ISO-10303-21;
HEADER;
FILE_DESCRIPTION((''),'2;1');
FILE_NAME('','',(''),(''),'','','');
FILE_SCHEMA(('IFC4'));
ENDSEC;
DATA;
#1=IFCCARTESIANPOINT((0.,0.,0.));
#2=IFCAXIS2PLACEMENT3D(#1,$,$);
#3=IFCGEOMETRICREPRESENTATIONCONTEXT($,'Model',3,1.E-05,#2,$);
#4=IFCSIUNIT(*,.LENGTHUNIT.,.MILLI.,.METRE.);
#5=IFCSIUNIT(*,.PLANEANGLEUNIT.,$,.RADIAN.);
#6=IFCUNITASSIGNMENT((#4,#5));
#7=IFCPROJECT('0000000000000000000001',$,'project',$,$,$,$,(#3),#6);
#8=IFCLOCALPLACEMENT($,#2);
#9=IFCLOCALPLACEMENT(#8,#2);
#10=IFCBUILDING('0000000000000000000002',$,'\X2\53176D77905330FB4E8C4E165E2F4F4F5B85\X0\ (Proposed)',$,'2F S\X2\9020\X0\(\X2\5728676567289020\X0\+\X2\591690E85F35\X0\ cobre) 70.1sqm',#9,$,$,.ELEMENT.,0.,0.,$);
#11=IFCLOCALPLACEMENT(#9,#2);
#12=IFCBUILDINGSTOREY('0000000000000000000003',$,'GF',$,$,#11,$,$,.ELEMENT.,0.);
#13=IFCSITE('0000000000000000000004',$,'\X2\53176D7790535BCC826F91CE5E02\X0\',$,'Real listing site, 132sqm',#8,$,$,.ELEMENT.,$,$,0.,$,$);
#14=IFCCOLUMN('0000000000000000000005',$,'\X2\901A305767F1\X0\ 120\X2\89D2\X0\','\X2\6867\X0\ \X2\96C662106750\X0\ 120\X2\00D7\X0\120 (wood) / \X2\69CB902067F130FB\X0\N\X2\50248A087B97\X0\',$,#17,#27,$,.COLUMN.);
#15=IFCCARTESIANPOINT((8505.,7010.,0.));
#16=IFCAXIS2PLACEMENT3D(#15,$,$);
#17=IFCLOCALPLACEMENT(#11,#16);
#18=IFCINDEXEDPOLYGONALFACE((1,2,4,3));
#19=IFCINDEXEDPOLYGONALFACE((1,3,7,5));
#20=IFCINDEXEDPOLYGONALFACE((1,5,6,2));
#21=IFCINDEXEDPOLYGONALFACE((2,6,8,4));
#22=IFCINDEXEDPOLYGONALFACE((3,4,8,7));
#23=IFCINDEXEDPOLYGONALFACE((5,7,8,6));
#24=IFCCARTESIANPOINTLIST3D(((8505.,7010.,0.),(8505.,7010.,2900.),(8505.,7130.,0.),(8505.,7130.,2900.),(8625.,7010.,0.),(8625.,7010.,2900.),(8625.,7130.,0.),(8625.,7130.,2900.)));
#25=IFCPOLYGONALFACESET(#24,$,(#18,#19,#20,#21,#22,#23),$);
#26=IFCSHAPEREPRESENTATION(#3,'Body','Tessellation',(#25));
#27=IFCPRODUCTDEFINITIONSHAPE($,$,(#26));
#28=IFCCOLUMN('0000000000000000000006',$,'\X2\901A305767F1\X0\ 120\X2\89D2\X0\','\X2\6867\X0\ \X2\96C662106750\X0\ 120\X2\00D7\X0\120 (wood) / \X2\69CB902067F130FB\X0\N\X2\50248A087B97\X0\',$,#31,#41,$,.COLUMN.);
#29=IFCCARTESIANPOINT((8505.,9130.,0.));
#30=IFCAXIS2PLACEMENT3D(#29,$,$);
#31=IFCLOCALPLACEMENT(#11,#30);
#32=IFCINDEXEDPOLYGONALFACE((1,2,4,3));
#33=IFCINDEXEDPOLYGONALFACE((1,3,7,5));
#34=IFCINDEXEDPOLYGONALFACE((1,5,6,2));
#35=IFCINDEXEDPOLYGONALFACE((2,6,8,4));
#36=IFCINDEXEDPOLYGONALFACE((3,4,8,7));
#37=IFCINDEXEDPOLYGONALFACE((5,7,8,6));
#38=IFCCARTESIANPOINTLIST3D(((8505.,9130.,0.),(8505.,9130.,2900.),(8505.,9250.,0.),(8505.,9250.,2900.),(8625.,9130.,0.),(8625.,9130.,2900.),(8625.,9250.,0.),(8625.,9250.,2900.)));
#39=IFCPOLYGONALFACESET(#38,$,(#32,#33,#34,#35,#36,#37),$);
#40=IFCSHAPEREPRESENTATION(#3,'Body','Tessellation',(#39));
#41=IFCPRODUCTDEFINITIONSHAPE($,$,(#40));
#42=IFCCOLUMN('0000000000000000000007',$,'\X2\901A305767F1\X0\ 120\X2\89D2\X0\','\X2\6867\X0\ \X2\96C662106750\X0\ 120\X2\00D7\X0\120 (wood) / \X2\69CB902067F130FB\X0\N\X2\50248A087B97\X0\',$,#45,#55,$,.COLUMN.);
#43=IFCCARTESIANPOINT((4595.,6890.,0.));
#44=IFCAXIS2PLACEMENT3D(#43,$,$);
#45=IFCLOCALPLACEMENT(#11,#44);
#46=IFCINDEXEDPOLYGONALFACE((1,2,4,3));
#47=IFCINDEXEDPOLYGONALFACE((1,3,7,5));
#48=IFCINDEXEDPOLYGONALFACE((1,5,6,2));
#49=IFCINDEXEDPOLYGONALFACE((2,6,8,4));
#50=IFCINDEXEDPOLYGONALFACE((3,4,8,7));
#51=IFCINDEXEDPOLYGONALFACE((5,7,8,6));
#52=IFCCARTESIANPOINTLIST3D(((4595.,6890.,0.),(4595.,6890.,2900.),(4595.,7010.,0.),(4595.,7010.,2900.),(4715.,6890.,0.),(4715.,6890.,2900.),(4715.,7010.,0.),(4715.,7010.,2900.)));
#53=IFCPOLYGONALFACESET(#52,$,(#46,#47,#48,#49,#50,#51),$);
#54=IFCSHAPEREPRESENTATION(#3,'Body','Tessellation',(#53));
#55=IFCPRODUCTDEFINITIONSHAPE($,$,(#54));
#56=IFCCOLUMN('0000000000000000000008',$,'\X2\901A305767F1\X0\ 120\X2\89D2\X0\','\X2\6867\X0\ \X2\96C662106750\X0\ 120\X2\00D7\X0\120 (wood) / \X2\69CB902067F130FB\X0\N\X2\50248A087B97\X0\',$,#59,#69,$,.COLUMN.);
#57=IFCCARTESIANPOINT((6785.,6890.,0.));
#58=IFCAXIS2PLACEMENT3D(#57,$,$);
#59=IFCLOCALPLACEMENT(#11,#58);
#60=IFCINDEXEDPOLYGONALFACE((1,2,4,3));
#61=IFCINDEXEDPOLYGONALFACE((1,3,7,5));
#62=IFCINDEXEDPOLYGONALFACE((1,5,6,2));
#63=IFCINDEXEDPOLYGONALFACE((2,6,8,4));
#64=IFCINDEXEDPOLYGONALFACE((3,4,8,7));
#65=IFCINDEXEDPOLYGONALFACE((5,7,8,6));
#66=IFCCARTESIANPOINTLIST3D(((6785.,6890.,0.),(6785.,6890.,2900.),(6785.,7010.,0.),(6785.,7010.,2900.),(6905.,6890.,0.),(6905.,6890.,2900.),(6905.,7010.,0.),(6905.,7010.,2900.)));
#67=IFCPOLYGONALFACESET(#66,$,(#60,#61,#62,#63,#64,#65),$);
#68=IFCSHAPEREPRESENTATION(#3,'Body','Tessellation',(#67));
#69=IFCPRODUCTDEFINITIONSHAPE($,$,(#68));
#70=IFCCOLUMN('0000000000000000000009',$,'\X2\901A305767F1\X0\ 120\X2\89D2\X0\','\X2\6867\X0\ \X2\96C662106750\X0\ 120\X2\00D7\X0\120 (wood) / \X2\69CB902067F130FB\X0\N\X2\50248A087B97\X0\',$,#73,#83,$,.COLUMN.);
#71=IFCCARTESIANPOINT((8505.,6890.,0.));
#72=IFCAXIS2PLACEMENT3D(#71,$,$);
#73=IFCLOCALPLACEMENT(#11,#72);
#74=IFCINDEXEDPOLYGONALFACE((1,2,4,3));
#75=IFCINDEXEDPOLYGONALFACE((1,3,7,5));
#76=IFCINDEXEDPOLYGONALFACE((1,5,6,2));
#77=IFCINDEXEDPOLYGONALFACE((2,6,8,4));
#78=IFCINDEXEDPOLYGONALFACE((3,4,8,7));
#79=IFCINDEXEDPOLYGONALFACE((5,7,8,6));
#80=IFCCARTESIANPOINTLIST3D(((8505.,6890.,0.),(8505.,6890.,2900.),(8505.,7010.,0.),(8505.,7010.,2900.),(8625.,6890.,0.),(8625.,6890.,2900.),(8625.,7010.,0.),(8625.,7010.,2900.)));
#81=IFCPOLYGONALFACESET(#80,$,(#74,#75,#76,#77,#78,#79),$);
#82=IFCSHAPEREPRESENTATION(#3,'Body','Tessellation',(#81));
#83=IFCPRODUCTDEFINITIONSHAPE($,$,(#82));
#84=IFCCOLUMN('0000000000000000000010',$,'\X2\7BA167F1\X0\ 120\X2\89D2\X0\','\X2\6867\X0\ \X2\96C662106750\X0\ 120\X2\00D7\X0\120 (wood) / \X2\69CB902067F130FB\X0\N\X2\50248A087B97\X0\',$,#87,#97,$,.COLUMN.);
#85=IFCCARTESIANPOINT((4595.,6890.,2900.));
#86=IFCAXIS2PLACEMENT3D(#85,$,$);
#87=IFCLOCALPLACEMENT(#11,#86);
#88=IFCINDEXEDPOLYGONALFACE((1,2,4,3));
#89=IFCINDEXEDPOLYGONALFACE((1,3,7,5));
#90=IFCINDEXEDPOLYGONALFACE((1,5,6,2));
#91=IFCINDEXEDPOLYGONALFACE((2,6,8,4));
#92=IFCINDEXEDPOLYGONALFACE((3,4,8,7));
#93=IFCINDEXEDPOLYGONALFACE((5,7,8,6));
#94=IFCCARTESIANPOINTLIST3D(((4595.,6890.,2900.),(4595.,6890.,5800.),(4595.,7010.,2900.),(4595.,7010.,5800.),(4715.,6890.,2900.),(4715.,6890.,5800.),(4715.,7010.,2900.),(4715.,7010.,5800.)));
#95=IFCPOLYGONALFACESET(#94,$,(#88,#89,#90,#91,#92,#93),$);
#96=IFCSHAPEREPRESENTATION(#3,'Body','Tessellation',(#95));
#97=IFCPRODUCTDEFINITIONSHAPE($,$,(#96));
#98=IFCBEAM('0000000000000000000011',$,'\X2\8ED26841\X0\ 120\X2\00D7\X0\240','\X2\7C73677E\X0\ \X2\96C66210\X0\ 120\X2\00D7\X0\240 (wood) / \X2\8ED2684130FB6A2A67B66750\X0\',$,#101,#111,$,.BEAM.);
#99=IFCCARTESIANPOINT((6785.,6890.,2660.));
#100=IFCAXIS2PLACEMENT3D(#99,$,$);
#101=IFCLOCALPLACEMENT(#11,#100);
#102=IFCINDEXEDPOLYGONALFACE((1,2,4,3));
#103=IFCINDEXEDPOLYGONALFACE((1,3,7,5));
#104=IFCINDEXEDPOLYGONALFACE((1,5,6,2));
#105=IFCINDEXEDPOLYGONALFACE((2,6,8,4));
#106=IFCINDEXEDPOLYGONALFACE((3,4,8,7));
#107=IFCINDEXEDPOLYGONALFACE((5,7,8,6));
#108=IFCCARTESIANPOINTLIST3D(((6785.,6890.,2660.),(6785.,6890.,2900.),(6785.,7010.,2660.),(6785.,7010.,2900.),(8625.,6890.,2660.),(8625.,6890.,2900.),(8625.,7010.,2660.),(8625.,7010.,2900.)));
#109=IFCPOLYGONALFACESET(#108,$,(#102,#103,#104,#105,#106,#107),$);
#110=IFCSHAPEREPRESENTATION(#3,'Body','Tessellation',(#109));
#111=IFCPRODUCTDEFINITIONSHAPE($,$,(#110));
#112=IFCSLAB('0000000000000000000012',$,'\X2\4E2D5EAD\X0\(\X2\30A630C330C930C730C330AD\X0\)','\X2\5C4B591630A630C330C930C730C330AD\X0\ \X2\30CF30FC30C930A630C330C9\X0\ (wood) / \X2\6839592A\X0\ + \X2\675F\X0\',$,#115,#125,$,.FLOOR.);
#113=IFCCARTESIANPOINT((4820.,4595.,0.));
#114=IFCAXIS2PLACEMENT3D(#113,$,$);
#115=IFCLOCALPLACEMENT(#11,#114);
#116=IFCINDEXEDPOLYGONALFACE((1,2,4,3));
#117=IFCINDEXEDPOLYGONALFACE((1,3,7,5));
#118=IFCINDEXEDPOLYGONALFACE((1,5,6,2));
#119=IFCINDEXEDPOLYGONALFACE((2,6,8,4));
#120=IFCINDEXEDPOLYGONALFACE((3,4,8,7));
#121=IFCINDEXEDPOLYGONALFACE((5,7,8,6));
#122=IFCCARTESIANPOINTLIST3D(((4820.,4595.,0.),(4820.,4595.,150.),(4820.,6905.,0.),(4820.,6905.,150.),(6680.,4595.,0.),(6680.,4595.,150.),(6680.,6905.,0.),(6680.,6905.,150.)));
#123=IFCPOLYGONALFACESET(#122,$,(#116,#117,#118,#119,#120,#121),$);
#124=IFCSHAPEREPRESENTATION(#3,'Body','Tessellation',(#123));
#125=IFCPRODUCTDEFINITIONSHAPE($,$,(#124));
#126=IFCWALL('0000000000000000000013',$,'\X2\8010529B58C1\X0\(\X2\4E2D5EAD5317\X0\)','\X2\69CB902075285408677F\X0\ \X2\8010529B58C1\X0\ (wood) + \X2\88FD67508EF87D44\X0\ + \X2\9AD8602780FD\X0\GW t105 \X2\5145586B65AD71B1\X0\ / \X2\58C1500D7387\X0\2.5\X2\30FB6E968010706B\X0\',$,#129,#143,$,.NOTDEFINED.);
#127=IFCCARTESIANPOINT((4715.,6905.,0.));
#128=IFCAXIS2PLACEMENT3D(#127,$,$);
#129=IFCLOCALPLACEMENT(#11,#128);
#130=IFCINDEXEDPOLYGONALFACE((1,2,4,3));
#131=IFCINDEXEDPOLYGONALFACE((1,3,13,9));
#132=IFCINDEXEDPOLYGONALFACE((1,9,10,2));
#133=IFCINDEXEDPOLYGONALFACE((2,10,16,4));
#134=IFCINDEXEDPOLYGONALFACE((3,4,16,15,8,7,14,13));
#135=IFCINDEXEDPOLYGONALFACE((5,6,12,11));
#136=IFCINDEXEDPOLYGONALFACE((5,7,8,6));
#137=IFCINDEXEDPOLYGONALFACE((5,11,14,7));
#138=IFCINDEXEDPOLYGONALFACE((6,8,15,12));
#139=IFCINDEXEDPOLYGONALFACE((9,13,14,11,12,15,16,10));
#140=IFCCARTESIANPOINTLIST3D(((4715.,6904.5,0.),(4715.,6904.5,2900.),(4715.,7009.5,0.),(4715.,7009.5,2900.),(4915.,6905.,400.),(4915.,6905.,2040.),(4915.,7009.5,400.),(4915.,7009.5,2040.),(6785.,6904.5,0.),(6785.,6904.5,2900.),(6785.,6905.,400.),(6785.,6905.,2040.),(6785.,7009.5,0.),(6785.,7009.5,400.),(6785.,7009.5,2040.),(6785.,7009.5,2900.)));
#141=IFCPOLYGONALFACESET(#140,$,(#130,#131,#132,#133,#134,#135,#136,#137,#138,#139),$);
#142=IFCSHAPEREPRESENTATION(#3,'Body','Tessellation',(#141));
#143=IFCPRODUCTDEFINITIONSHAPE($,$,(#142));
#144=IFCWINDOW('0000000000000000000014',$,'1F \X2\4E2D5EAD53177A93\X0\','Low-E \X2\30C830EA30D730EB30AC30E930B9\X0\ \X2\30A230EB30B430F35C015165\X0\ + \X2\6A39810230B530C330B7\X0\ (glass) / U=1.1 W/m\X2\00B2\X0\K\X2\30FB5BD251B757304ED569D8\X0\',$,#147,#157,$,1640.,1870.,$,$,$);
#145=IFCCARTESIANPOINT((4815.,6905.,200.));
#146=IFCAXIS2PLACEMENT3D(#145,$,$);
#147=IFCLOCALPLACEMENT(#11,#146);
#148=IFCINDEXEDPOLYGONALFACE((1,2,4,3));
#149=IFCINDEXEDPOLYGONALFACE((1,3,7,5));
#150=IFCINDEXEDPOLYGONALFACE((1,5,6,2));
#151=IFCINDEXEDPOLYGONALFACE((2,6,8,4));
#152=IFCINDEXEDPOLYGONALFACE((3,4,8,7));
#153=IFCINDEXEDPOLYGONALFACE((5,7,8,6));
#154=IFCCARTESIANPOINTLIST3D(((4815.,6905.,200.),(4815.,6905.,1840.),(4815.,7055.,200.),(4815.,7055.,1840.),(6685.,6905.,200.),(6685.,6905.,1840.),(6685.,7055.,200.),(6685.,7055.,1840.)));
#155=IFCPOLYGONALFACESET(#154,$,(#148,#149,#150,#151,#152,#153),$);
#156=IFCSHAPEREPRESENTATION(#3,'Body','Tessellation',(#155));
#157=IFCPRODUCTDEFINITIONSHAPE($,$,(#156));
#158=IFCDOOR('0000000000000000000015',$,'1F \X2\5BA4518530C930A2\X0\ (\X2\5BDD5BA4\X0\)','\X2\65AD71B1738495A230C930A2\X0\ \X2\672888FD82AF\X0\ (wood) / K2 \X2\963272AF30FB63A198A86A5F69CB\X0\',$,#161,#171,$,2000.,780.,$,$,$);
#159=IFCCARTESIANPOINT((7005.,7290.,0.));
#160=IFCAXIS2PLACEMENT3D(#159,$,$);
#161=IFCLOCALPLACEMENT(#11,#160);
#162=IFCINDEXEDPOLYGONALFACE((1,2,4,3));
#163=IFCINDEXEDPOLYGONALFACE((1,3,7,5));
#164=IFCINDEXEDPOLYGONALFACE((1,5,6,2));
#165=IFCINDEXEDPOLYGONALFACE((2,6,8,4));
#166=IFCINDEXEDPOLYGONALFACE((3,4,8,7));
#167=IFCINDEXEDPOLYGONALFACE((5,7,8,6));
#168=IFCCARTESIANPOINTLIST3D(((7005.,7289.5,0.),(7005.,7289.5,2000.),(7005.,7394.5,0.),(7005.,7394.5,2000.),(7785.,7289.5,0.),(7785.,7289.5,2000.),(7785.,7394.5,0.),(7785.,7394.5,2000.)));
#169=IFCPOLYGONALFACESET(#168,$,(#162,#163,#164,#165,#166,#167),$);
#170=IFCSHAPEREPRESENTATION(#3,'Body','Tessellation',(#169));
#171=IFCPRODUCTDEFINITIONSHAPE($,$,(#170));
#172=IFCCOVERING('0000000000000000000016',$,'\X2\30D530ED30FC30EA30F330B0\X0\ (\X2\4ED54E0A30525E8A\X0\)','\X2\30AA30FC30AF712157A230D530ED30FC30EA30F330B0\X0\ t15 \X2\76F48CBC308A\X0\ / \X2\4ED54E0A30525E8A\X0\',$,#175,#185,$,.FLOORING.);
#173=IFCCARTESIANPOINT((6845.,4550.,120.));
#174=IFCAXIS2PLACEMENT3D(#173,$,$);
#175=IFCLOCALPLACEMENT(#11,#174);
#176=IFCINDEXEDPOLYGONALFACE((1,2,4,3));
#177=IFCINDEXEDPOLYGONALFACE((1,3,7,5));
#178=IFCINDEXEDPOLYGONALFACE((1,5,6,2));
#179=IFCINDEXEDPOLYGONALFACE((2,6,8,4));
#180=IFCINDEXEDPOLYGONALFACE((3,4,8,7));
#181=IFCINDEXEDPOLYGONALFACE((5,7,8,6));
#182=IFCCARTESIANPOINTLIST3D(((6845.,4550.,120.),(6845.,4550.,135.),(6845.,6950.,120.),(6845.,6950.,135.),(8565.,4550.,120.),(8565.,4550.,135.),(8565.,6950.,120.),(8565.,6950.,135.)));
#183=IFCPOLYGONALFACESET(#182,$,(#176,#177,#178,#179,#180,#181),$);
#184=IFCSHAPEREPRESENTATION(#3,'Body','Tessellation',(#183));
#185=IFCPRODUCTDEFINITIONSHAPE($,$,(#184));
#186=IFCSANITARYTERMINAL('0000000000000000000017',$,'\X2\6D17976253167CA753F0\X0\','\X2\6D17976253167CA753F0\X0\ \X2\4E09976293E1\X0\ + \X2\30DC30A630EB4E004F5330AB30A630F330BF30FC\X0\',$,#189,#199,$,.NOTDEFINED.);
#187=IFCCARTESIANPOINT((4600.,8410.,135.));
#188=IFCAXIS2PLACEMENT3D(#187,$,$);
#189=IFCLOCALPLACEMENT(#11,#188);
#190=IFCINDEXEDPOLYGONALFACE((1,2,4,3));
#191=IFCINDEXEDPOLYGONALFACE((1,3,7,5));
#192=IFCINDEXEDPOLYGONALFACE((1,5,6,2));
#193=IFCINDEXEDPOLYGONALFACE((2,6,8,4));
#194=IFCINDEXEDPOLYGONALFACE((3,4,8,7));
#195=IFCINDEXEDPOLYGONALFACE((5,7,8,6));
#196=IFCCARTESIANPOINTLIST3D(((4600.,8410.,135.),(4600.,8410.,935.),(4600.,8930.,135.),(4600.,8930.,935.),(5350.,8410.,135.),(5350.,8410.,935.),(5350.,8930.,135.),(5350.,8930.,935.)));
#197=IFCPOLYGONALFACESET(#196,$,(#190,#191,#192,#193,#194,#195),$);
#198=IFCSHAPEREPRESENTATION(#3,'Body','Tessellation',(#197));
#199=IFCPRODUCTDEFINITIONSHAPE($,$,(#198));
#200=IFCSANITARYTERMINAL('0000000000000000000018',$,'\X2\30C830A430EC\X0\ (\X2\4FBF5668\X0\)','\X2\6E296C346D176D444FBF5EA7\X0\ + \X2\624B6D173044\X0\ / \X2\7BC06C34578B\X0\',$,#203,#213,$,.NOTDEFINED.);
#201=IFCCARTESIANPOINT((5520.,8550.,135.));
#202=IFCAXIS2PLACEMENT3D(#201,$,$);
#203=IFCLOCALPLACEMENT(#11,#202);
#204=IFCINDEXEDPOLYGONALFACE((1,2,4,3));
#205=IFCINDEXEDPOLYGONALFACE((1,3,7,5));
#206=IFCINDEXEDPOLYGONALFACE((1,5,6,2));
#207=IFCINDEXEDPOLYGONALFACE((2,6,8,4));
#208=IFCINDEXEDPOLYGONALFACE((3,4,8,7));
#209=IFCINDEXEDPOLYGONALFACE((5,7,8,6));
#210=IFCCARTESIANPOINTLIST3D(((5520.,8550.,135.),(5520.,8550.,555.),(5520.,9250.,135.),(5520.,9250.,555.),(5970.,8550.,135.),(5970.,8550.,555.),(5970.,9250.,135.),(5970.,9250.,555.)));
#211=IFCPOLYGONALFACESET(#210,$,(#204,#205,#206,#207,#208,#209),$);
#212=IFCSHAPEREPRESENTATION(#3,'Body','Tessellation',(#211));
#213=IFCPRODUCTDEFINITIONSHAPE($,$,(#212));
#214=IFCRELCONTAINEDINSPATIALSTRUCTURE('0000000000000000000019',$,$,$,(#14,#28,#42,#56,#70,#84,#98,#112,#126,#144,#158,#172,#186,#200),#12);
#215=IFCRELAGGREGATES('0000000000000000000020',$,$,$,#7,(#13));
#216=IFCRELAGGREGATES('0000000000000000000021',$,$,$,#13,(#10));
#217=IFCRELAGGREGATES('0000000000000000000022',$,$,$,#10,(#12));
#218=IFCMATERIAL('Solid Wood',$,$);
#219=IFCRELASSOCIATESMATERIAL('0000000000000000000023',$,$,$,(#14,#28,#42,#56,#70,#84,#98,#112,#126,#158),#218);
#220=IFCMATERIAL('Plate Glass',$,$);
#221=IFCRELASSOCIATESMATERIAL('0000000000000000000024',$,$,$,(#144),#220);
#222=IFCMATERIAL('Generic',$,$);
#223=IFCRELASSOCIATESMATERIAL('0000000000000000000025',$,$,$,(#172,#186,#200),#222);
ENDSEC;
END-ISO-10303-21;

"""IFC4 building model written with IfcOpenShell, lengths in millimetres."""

from ifc_helpers import new_model, si_unit, frame, frame_2d, origin, place, context, project, spatial, rectangle, extrude, material, element, fill, save


model = new_model("IFC4")

# Units and contexts
model_context = context("Model", 3, precision=1e-05, world=origin())
ifc_project = project(units=[si_unit("LENGTHUNIT", "METRE", prefix="MILLI"), si_unit("PLANEANGLEUNIT", "RADIAN")], contexts=[model_context])

# Site, building, storey
site_placement = place(None, origin())
site = spatial("IfcSite", under=ifc_project, at=site_placement, Name="北海道富良野市", ObjectType="Real listing site, 132sqm", CompositionType="ELEMENT", RefElevation=0.0)
building_placement = place(site_placement, origin())
building = spatial("IfcBuilding", under=site, at=building_placement, Name="北海道・二世帯住宅 (Proposed)", ObjectType="2F S造(在来木造+外部張 cobre) 70.1sqm", CompositionType="ELEMENT", ElevationOfRefHeight=0.0, ElevationOfTerrain=0.0)
storey_placement = place(building_placement, origin())
storey = spatial("IfcBuildingStorey", under=building, at=storey_placement, Name="GF", CompositionType="ELEMENT", Elevation=0.0)

# Columns
ifc_material_1 = material(Name="Solid Wood")
column_1_placement = place(storey_placement, frame((8505.0, 7010.0, 0.0)))
element("IfcColumn", 1, at=column_1_placement, inside=storey, material=ifc_material_1, Name="通し柱 120角", Description="桧 集成材 120×120 (wood) / 構造柱・N値計算", PredefinedType="COLUMN", context=model_context, shape_type="SweptSolid", body=[
    extrude(rectangle(XDim=120.0, YDim=120.0, at=frame_2d((60.0, 60.0))), frame((8505.0, 7010.0, 0.0)), (0.0, 0.0, 1.0), 2900.0),
])
column_2_placement = place(storey_placement, frame((8505.0, 9130.0, 0.0)))
element("IfcColumn", 2, at=column_2_placement, inside=storey, material=ifc_material_1, Name="通し柱 120角", Description="桧 集成材 120×120 (wood) / 構造柱・N値計算", PredefinedType="COLUMN", context=model_context, shape_type="SweptSolid", body=[
    extrude(rectangle(XDim=120.0, YDim=120.0, at=frame_2d((60.0, 60.0))), frame((8505.0, 9130.0, 0.0)), (0.0, 0.0, 1.0), 2900.0),
])
column_3_placement = place(storey_placement, frame((4595.0, 6890.0, 0.0)))
element("IfcColumn", 3, at=column_3_placement, inside=storey, material=ifc_material_1, Name="通し柱 120角", Description="桧 集成材 120×120 (wood) / 構造柱・N値計算", PredefinedType="COLUMN", context=model_context, shape_type="SweptSolid", body=[
    extrude(rectangle(XDim=120.0, YDim=120.0, at=frame_2d((60.0, 60.0))), frame((4595.0, 6890.0, 0.0)), (0.0, 0.0, 1.0), 2900.0),
])
column_4_placement = place(storey_placement, frame((6785.0, 6890.0, 0.0)))
element("IfcColumn", 4, at=column_4_placement, inside=storey, material=ifc_material_1, Name="通し柱 120角", Description="桧 集成材 120×120 (wood) / 構造柱・N値計算", PredefinedType="COLUMN", context=model_context, shape_type="SweptSolid", body=[
    extrude(rectangle(XDim=120.0, YDim=120.0, at=frame_2d((60.0, 60.0))), frame((6785.0, 6890.0, 0.0)), (0.0, 0.0, 1.0), 2900.0),
])
column_5_placement = place(storey_placement, frame((8505.0, 6890.0, 0.0)))
element("IfcColumn", 5, at=column_5_placement, inside=storey, material=ifc_material_1, Name="通し柱 120角", Description="桧 集成材 120×120 (wood) / 構造柱・N値計算", PredefinedType="COLUMN", context=model_context, shape_type="SweptSolid", body=[
    extrude(rectangle(XDim=120.0, YDim=120.0, at=frame_2d((60.0, 60.0))), frame((8505.0, 6890.0, 0.0)), (0.0, 0.0, 1.0), 2900.0),
])
column_6_placement = place(storey_placement, frame((4595.0, 6890.0, 2900.0)))
element("IfcColumn", 6, at=column_6_placement, inside=storey, material=ifc_material_1, Name="管柱 120角", Description="桧 集成材 120×120 (wood) / 構造柱・N値計算", PredefinedType="COLUMN", context=model_context, shape_type="SweptSolid", body=[
    extrude(rectangle(XDim=120.0, YDim=120.0, at=frame_2d((60.0, 60.0))), frame((4595.0, 6890.0, 2900.0)), (0.0, 0.0, 1.0), 2900.0),
])

# Beam
beam_1_placement = place(storey_placement, frame((6785.0, 6890.0, 2660.0)))
element("IfcBeam", 7, at=beam_1_placement, inside=storey, material=ifc_material_1, Name="軒桁 120×240", Description="米松 集成 120×240 (wood) / 軒桁・横架材", PredefinedType="BEAM", context=model_context, shape_type="SweptSolid", body=[
    extrude(rectangle(XDim=1840.0, YDim=120.0, at=frame_2d((920.0, 60.0))), frame((6785.0, 6890.0, 2660.0)), (0.0, 0.0, 1.0), 240.0),
])

# Slab
slab_placement = place(storey_placement, frame((4820.0, 4595.0, 0.0)))
element("IfcSlab", 8, at=slab_placement, inside=storey, material=ifc_material_1, Name="中庭(ウッドデッキ)", Description="屋外ウッドデッキ ハードウッド (wood) / 根太 + 束", PredefinedType="FLOOR", context=model_context, shape_type="SweptSolid", body=[
    extrude(rectangle(XDim=1860.0, YDim=2310.0, at=frame_2d((930.0, 1155.0))), frame((4820.0, 4595.0, 0.0)), (0.0, 0.0, 1.0), 150.0),
])

# Wall, opening, window
wall_1_placement = place(storey_placement, frame((4715.0, 6905.0, 0.0)))
wall_1 = element("IfcWall", 9, at=wall_1_placement, inside=storey, material=ifc_material_1, Name="耐力壁(中庭北)", Description="構造用合板 耐力壁 (wood) + 製材軸組 + 高性能GW t105 充填断熱 / 壁倍率2.5・準耐火", PredefinedType="NOTDEFINED", context=model_context, shape_type="SweptSolid", body=[
    extrude(rectangle(XDim=2070.0, YDim=105.0, at=frame_2d((1035.0, 52.0))), frame((4715.0, 6905.0, 0.0)), (0.0, 0.0, 1.0), 2900.0),
])
opening_placement = place(storey_placement, frame((4815.0, 6905.0, 200.0)))
opening = element("IfcOpeningElement", 10, at=opening_placement, cuts=wall_1, PredefinedType="NOTDEFINED", context=model_context, shape_type="SweptSolid", body=[
    extrude(rectangle(XDim=1870.0, YDim=150.0, at=frame_2d((935.0, 75.0))), frame((4815.0, 6905.0, 200.0)), (0.0, 0.0, 1.0), 1640.0),
])
ifc_material_2 = material(Name="Plate Glass")
window_placement = place(storey_placement, frame((4815.0, 6905.0, 200.0)))
window = element("IfcWindow", 11, at=window_placement, inside=storey, material=ifc_material_2, Name="1F 中庭北窓", Description="Low-E トリプルガラス アルゴン封入 + 樹脂サッシ (glass) / U=1.1 W/m²K・寒冷地仕様", OverallHeight=1640.0, OverallWidth=1870.0, context=model_context, shape_type="SweptSolid", body=[
    extrude(rectangle(XDim=1870.0, YDim=150.0, at=frame_2d((935.0, 75.0))), frame((4815.0, 6905.0, 200.0)), (0.0, 0.0, 1.0), 1640.0),
])
fill(opening, window)

# Door
door_placement = place(storey_placement, frame((7005.0, 7290.0, 0.0)))
element("IfcDoor", 12, at=door_placement, inside=storey, material=ifc_material_1, Name="1F 室内ドア (寝室)", Description="断熱玄関ドア 木製芯 (wood) / K2 防犯・採風機構", OverallHeight=2000.0, OverallWidth=780.0, context=model_context, shape_type="SweptSolid", body=[
    extrude(rectangle(XDim=780.0, YDim=105.0, at=frame_2d((390.0, 52.0))), frame((7005.0, 7290.0, 0.0)), (0.0, 0.0, 1.0), 2000.0),
])

# Covering
ifc_material_3 = material(Name="Generic")
covering_placement = place(storey_placement, frame((6845.0, 4550.0, 120.0)))
element("IfcCovering", 13, at=covering_placement, inside=storey, material=ifc_material_3, Name="フローリング (仕上げ床)", Description="オーク無垢フローリング t15 直貼り / 仕上げ床", PredefinedType="FLOORING", context=model_context, shape_type="SweptSolid", body=[
    extrude(rectangle(XDim=1720.0, YDim=2400.0, at=frame_2d((860.0, 1200.0))), frame((6845.0, 4550.0, 120.0)), (0.0, 0.0, 1.0), 15.0),
])

# Sanitary terminals
sanitary_terminal_1_placement = place(storey_placement, frame((4600.0, 8410.0, 135.0)))
element("IfcSanitaryTerminal", 14, at=sanitary_terminal_1_placement, inside=storey, material=ifc_material_3, Name="洗面化粧台", Description="洗面化粧台 三面鏡 + ボウル一体カウンター", PredefinedType="NOTDEFINED", context=model_context, shape_type="SweptSolid", body=[
    extrude(rectangle(XDim=750.0, YDim=520.0, at=frame_2d((375.0, 260.0))), frame((4600.0, 8410.0, 135.0)), (0.0, 0.0, 1.0), 800.0),
])
sanitary_terminal_2_placement = place(storey_placement, frame((5520.0, 8550.0, 135.0)))
element("IfcSanitaryTerminal", 15, at=sanitary_terminal_2_placement, inside=storey, material=ifc_material_3, Name="トイレ (便器)", Description="温水洗浄便座 + 手洗い / 節水型", PredefinedType="NOTDEFINED", context=model_context, shape_type="SweptSolid", body=[
    extrude(rectangle(XDim=450.0, YDim=700.0, at=frame_2d((225.0, 350.0))), frame((5520.0, 8550.0, 135.0)), (0.0, 0.0, 1.0), 420.0),
])

save(model, "model.ifc")
